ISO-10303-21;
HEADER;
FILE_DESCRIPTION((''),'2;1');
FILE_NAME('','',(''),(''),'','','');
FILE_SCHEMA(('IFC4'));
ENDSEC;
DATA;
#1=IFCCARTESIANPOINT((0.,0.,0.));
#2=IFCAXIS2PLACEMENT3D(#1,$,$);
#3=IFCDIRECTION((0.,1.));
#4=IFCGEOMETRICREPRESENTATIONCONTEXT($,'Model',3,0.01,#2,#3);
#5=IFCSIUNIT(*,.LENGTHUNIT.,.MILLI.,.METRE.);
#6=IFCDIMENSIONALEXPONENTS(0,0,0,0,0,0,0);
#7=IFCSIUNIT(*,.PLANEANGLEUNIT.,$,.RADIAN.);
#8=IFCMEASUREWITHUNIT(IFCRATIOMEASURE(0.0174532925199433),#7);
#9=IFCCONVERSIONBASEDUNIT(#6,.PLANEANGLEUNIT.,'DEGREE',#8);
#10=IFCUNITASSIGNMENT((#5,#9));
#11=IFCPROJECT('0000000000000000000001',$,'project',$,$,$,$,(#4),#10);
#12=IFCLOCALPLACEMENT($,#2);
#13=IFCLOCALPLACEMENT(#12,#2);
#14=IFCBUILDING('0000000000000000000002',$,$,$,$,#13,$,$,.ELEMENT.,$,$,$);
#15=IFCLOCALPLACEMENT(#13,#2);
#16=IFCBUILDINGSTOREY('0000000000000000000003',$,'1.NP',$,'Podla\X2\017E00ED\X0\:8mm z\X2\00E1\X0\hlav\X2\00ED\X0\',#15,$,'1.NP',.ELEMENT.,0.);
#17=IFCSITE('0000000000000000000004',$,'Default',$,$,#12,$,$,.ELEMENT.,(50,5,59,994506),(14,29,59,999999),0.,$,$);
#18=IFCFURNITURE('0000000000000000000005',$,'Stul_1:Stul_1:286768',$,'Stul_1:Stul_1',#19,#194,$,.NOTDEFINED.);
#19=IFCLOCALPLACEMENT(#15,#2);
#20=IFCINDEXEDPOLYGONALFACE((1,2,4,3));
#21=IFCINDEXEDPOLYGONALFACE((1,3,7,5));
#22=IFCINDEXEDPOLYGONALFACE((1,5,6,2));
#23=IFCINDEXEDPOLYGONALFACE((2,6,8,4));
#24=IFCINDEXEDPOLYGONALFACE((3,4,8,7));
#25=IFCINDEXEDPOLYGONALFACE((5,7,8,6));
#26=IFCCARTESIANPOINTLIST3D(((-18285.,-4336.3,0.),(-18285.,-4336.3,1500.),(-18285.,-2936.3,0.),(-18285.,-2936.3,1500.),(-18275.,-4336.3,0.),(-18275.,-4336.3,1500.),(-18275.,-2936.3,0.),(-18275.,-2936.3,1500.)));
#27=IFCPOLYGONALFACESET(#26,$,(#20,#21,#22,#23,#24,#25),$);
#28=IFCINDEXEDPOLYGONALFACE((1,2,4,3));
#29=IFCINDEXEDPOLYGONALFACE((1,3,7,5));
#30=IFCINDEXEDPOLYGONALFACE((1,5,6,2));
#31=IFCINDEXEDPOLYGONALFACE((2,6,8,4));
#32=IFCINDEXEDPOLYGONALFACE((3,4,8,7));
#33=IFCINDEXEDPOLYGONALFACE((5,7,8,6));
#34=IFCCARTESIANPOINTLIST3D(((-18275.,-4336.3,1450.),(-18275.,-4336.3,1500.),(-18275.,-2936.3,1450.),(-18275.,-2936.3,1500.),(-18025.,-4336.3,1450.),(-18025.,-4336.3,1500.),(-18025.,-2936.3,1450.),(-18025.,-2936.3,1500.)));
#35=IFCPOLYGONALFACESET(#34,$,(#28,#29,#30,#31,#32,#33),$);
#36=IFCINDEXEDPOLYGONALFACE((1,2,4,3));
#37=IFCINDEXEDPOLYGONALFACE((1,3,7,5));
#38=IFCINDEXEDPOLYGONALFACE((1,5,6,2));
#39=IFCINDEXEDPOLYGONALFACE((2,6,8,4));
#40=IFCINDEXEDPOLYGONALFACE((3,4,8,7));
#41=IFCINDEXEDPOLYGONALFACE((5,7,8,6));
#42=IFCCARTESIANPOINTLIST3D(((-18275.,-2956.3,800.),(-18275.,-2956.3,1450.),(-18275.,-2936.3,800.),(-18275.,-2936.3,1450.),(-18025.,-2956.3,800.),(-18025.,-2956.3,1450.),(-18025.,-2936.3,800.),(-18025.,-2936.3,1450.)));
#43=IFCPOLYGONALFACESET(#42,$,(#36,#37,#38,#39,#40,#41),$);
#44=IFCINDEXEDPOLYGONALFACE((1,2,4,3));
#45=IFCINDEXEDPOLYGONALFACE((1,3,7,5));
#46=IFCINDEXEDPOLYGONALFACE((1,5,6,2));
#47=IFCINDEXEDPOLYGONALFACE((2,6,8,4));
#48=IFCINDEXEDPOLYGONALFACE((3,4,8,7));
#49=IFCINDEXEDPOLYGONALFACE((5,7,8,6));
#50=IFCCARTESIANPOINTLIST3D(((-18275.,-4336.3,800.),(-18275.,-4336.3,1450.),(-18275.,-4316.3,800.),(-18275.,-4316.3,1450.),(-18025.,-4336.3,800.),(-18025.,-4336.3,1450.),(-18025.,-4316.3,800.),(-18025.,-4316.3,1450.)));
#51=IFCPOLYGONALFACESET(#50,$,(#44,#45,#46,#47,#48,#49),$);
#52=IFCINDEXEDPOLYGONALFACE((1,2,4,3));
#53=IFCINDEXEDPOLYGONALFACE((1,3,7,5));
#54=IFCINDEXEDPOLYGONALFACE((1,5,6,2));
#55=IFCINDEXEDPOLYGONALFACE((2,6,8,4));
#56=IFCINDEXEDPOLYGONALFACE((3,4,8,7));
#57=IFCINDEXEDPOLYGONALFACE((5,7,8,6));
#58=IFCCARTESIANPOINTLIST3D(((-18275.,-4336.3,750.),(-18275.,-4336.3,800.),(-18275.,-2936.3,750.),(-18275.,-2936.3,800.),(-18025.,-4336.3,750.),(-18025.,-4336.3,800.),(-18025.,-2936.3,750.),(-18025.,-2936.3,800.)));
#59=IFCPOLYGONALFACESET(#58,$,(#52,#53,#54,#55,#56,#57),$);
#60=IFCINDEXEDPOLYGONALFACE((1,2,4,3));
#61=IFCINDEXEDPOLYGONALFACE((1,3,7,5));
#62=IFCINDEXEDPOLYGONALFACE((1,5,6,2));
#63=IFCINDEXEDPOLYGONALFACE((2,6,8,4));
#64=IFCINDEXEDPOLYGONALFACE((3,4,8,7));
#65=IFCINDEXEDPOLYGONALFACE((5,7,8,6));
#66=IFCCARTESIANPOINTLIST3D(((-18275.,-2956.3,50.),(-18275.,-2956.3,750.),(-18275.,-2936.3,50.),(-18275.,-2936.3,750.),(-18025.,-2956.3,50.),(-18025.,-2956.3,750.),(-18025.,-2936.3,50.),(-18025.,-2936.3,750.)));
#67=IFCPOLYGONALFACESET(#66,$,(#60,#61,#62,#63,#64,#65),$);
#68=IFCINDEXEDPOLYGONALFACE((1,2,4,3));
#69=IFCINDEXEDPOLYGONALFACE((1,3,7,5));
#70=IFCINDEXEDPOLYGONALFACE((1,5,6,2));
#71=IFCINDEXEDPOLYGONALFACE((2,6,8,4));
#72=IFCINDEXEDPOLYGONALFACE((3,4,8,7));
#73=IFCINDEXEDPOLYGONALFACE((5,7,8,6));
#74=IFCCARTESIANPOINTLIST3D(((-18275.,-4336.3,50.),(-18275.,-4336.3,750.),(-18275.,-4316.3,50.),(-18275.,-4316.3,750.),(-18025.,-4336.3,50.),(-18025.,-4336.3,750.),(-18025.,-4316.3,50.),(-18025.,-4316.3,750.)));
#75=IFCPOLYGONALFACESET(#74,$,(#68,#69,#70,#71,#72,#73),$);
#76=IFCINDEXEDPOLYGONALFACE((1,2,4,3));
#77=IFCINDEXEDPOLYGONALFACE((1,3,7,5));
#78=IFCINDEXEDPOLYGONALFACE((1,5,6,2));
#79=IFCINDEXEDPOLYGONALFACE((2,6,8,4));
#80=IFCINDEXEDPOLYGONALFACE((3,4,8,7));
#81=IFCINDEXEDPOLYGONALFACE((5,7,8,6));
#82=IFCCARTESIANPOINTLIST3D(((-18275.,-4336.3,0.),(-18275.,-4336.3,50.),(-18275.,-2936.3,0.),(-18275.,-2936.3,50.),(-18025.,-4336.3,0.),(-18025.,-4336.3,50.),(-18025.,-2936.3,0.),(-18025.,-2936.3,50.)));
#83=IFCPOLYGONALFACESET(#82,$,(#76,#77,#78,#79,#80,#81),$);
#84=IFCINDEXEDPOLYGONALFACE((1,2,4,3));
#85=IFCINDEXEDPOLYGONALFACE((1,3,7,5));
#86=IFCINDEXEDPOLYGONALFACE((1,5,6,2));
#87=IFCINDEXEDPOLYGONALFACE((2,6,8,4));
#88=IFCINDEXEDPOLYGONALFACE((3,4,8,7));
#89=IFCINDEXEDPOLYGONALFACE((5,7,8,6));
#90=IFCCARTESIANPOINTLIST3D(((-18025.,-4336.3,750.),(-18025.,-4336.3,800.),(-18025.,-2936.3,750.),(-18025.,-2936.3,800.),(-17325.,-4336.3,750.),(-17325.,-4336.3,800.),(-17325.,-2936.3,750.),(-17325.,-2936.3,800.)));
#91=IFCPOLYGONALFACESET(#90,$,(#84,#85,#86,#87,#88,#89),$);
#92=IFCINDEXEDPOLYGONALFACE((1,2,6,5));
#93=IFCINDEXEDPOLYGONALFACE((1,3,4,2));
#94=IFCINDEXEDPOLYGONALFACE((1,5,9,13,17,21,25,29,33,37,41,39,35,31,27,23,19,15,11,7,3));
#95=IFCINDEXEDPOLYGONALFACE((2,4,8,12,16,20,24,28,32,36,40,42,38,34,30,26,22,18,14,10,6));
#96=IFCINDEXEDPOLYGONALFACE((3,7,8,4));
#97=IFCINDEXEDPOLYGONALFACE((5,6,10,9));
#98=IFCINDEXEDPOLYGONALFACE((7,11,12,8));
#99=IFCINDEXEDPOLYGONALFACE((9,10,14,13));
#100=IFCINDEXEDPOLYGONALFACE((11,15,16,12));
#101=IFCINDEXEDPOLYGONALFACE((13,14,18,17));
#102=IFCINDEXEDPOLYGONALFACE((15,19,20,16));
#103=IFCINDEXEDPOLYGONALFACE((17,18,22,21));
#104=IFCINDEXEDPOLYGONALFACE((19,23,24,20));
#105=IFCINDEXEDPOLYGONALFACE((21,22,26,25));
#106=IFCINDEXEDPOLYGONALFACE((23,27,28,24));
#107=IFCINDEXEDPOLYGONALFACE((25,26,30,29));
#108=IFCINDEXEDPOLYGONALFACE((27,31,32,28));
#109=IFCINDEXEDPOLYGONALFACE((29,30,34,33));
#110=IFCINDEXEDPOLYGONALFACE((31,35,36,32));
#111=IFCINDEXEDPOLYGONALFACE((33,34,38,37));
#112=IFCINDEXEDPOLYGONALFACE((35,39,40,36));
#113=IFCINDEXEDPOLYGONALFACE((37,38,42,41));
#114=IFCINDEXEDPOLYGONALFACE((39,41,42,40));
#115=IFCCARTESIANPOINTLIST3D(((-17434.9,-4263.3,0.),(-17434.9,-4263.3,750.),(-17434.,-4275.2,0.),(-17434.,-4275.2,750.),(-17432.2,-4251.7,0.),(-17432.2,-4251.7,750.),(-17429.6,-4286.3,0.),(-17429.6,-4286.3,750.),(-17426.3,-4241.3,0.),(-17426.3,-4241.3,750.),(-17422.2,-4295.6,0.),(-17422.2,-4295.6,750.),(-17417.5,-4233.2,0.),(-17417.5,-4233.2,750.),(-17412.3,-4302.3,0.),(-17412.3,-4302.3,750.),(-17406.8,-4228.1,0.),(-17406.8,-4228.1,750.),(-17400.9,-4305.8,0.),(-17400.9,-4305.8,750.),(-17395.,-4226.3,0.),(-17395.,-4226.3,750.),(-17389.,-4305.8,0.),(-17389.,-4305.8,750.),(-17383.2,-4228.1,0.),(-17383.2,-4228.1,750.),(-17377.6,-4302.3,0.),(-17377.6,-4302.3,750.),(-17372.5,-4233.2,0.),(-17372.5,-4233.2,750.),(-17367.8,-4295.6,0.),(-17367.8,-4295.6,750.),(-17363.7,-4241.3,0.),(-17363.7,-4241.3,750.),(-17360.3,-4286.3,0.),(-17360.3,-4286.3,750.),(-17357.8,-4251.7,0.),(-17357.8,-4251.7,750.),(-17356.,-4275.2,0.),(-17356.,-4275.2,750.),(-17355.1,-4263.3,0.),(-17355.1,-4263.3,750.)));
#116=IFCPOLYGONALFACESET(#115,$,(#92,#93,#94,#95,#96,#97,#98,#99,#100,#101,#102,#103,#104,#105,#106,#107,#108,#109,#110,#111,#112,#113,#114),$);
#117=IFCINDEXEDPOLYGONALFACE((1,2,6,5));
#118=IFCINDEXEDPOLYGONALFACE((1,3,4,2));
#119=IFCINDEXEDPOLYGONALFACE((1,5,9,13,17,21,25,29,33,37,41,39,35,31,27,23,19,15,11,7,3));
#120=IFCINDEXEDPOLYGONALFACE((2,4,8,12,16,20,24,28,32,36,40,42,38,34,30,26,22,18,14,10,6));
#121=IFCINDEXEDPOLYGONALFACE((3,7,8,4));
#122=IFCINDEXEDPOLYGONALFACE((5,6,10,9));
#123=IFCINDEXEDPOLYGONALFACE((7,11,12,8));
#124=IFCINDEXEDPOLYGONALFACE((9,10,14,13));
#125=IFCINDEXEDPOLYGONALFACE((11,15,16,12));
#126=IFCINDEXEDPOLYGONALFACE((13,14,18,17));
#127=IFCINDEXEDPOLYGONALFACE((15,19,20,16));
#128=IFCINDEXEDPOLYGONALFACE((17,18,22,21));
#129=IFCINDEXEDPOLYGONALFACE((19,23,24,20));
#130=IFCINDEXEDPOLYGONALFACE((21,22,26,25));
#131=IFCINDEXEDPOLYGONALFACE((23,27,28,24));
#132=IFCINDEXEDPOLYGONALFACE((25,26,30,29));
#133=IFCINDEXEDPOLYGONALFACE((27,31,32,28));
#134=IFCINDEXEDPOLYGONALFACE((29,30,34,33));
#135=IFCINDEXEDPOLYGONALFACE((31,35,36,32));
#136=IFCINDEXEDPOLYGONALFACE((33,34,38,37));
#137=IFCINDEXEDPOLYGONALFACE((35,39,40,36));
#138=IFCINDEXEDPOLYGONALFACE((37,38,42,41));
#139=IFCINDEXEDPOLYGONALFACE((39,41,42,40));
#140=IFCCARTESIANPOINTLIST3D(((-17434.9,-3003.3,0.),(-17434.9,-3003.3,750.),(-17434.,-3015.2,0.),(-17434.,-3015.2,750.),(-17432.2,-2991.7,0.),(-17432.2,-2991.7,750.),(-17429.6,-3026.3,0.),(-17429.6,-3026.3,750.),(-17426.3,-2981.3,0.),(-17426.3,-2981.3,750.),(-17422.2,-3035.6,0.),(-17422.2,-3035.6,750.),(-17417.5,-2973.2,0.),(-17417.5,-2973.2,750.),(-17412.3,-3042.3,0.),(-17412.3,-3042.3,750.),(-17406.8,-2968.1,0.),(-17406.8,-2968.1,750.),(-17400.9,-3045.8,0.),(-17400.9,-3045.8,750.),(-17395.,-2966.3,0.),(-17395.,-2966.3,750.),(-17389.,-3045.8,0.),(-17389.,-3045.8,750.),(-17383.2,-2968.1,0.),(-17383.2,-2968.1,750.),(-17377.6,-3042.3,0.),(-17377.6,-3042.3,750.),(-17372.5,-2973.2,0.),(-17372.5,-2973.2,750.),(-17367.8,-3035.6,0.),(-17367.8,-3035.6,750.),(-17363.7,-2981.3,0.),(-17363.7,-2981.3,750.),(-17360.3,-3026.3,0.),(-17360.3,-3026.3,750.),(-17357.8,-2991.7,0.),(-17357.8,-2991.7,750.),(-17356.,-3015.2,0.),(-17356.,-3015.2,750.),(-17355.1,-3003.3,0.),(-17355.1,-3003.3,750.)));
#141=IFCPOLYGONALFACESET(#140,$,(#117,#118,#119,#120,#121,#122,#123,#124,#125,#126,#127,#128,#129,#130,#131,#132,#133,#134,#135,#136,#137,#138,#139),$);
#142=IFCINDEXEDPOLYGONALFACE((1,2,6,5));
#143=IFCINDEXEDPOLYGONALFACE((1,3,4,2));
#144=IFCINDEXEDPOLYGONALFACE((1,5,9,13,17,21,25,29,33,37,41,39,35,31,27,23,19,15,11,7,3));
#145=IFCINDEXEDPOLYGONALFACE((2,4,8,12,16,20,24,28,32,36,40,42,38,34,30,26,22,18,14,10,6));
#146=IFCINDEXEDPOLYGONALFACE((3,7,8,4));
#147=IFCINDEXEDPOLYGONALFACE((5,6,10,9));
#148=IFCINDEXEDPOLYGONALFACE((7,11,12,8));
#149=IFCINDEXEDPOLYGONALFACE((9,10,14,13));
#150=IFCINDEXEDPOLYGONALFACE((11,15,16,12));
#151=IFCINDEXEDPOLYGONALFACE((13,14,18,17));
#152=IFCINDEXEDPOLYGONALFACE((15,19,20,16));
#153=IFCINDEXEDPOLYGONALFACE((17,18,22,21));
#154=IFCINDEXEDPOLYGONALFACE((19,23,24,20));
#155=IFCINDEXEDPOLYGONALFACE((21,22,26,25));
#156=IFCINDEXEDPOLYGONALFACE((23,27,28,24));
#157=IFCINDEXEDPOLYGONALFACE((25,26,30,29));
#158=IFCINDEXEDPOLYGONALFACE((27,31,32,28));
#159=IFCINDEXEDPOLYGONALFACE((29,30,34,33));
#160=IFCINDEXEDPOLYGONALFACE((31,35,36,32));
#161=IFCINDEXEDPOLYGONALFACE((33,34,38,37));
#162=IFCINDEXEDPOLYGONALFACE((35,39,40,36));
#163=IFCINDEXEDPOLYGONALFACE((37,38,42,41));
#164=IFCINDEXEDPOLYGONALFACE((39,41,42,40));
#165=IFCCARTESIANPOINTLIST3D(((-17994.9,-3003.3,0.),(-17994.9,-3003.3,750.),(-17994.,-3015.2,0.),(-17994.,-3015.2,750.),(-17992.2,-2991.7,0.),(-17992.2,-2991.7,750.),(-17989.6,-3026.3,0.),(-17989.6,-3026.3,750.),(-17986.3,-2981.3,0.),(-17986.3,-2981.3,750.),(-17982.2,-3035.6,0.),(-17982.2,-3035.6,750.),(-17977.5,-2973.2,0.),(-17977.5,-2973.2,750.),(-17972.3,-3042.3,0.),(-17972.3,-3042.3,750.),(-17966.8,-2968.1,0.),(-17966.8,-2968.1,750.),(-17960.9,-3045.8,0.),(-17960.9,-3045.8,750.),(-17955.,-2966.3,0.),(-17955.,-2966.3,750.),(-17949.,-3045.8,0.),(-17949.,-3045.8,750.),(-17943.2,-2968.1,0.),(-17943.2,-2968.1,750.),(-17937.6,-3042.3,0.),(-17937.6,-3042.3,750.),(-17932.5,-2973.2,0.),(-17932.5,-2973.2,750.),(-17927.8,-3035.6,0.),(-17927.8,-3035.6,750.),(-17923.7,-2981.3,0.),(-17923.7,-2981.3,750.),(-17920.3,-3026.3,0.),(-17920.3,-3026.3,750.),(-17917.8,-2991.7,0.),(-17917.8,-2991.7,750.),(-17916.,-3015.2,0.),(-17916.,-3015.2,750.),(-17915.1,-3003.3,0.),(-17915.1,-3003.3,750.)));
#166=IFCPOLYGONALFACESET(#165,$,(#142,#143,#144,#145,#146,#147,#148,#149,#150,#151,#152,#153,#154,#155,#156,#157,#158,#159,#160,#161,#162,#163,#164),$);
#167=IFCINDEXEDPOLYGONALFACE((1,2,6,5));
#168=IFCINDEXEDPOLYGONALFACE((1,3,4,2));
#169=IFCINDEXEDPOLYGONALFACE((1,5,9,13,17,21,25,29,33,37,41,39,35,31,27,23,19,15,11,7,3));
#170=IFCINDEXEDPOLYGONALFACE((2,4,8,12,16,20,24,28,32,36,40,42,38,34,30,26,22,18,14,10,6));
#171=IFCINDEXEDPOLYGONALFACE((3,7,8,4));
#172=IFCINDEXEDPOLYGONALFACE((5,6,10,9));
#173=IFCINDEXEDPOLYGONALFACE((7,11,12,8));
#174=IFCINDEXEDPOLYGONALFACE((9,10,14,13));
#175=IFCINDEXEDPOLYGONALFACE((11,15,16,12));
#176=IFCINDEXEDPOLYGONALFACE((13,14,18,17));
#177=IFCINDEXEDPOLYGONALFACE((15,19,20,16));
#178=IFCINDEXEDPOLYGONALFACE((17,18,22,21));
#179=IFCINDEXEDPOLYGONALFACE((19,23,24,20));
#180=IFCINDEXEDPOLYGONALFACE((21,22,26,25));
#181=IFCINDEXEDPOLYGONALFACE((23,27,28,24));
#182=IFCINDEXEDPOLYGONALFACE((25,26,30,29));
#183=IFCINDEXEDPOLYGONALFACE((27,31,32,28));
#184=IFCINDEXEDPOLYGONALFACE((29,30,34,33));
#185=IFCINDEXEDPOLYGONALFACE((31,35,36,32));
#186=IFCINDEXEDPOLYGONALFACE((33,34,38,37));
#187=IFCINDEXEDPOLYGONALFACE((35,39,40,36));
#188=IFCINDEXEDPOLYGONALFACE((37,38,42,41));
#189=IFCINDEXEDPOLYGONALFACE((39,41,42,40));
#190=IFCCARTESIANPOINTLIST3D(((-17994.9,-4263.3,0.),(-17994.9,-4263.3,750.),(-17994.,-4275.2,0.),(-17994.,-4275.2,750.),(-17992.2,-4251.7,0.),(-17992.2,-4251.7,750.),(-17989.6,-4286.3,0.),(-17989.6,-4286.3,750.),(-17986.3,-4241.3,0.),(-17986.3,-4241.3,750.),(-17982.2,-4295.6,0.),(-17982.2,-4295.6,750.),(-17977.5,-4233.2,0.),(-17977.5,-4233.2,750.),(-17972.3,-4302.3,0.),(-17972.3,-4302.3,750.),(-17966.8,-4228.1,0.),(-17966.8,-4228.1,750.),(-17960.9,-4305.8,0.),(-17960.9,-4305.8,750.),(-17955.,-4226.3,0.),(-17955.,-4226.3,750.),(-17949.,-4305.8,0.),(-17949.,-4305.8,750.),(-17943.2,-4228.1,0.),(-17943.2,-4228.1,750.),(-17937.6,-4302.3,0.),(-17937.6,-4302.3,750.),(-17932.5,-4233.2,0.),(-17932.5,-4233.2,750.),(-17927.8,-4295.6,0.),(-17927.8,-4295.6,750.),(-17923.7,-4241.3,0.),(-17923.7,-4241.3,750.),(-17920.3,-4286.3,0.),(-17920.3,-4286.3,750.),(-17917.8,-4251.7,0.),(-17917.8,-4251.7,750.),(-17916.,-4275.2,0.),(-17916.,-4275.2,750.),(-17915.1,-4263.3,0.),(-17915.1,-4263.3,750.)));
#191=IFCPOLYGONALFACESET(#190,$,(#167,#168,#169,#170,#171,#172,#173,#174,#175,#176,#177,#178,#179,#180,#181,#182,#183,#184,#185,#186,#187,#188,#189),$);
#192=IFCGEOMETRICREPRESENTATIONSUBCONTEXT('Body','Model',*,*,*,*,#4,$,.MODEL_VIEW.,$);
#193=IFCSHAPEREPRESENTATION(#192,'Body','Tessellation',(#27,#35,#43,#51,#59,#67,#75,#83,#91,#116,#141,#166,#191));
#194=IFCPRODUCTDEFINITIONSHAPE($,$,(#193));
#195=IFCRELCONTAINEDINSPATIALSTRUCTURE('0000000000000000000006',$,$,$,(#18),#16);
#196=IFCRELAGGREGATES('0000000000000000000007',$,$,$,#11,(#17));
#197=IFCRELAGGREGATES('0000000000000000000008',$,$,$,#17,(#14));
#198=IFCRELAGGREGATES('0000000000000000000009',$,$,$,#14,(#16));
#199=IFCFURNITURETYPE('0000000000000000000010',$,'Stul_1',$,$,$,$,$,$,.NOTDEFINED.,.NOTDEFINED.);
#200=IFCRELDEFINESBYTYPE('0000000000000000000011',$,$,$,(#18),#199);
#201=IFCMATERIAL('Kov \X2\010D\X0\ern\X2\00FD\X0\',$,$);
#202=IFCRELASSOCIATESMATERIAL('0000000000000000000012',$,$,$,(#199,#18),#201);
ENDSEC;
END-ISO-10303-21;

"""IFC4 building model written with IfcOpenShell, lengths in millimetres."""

from ifc_helpers import new_model, entity, si_unit, converted_unit, direction, frame, frame_2d, origin, origin_2d_with_axis, place, context, subcontext, project, spatial, rectangle, circle, extrude, source, transform, mapped, material, type_object, type_shapes, element, save


model = new_model("IFC4")

# Units and contexts
model_context = context("Model", 3, precision=0.01, world=origin(), true_north=direction((0.0, 1.0)))
body_context = subcontext(model_context, "Body", "Model", "MODEL_VIEW")
ifc_project = project(units=[si_unit("LENGTHUNIT", "METRE", prefix="MILLI"), converted_unit("PLANEANGLEUNIT", "DEGREE", entity("IfcRatioMeasure", 0.0174532925199433), si_unit("PLANEANGLEUNIT", "RADIAN"), dimensions=[0, 0, 0, 0, 0, 0, 0])], contexts=[model_context])

# Site, building, storey
site_placement = place(None, origin())
site = spatial("IfcSite", under=ifc_project, at=site_placement, Name="Default", CompositionType="ELEMENT", RefLatitude=(50, 5, 59, 994506), RefLongitude=(14, 29, 59, 999999), RefElevation=0.0)
building_placement = place(site_placement, origin())
building = spatial("IfcBuilding", under=site, at=building_placement, CompositionType="ELEMENT")
storey_placement = place(building_placement, origin())
storey = spatial("IfcBuildingStorey", under=building, at=storey_placement, Name="1.NP", ObjectType="Podlaží:8mm záhlaví", LongName="1.NP", CompositionType="ELEMENT", Elevation=0.0)

# Furniture
ifc_material_1 = material(Name="Kov černý")
furniture_type = type_object("IfcFurnitureType", Name="Stul_1", AssemblyPlace="NOTDEFINED", PredefinedType="NOTDEFINED", material=ifc_material_1)
shared_shape_1 = source(origin(), body_context, "Body", "SweptSolid", [
    extrude(rectangle(XDim=1400.0, YDim=10.0, at=origin_2d_with_axis()), frame((0.0, 605.0, 0.0), z_axis=(0.0, 0.0, 1.0), x_axis=(-1.0, 0.0, 0.0)), (0.0, 0.0, 1.0), 1500.0),
    extrude(rectangle(XDim=1400.0, YDim=250.0, at=frame_2d((0.0, 0.0), x_axis=(1.0, 0.0))), frame((0.0, 475.0, 1450.0), z_axis=(0.0, 0.0, 1.0), x_axis=(-1.0, 0.0, 0.0)), (0.0, 0.0, 1.0), 50.0),
    extrude(rectangle(XDim=20.0, YDim=250.0, at=origin_2d_with_axis()), frame((690.0, 475.0, 800.0), z_axis=(0.0, 0.0, 1.0), x_axis=(-1.0, 0.0, 0.0)), (0.0, 0.0, 1.0), 650.0),
    extrude(rectangle(XDim=20.0, YDim=250.0, at=frame_2d((0.0, 0.0), x_axis=(1.0, 0.0))), frame((-690.0, 475.0, 800.0), z_axis=(0.0, 0.0, 1.0), x_axis=(-1.0, 0.0, 0.0)), (0.0, 0.0, 1.0), 650.0),
    extrude(rectangle(XDim=1400.0, YDim=250.0, at=origin_2d_with_axis()), frame((0.0, 475.0, 750.0), z_axis=(0.0, 0.0, 1.0), x_axis=(-1.0, 0.0, 0.0)), (0.0, 0.0, 1.0), 50.0),
    extrude(rectangle(XDim=20.0, YDim=250.0, at=origin_2d_with_axis()), frame((690.0, 475.0, 50.0), z_axis=(0.0, 0.0, 1.0), x_axis=(-1.0, 0.0, 0.0)), (0.0, 0.0, 1.0), 700.0),
    extrude(rectangle(XDim=20.0, YDim=250.0, at=frame_2d((0.0, 0.0), x_axis=(1.0, 0.0))), frame((-690.0, 475.0, 50.0), z_axis=(0.0, 0.0, 1.0), x_axis=(-1.0, 0.0, 0.0)), (0.0, 0.0, 1.0), 700.0),
    extrude(rectangle(XDim=1400.0, YDim=250.0, at=origin_2d_with_axis()), frame((0.0, 475.0, 0.0), z_axis=(0.0, 0.0, 1.0), x_axis=(-1.0, 0.0, 0.0)), (0.0, 0.0, 1.0), 50.0),
    extrude(rectangle(XDim=1400.0, YDim=700.0, at=origin_2d_with_axis()), frame((0.0, 0.0, 750.0), z_axis=(0.0, 0.0, 1.0), x_axis=(-1.0, 0.0, 0.0)), (0.0, 0.0, 1.0), 50.0),
    extrude(circle(Radius=40.0, at=frame_2d((0.0, 0.0), x_axis=(1.0, 0.0))), frame((-630.0, -280.0, 0.0)), (0.0, 0.0, 1.0), 750.0),
    extrude(circle(Radius=40.0, at=frame_2d((0.0, 0.0), x_axis=(1.0, 0.0))), frame((630.0, -280.0, 0.0)), (0.0, 0.0, 1.0), 750.0),
    extrude(circle(Radius=40.0, at=frame_2d((0.0, 0.0), x_axis=(1.0, 0.0))), frame((630.0, 280.0, 0.0)), (0.0, 0.0, 1.0), 750.0),
    extrude(circle(Radius=40.0, at=frame_2d((0.0, 0.0), x_axis=(1.0, 0.0))), frame((-630.0, 280.0, 0.0)), (0.0, 0.0, 1.0), 750.0),
])
type_shapes(furniture_type, [shared_shape_1])
for number, where, z_axis, x_axis, name in (
    (1, (-17675.0, -3636.3, 0.0), (0.0, 0.0, 1.0), (0.0, 1.0, 0.0), "Stul_1:Stul_1:286768"),
):
    element("IfcFurniture", number, at=place(storey_placement, frame(where, z_axis=z_axis, x_axis=x_axis)), inside=storey, type_object=furniture_type, material=ifc_material_1, Name=name, ObjectType="Stul_1:Stul_1", PredefinedType="NOTDEFINED", context=body_context, shape_type="MappedRepresentation", body=[
        mapped(shared_shape_1, transform((0.0, 0.0, 0.0), scale=1.0)),
    ])

save(model, "model.ifc")
